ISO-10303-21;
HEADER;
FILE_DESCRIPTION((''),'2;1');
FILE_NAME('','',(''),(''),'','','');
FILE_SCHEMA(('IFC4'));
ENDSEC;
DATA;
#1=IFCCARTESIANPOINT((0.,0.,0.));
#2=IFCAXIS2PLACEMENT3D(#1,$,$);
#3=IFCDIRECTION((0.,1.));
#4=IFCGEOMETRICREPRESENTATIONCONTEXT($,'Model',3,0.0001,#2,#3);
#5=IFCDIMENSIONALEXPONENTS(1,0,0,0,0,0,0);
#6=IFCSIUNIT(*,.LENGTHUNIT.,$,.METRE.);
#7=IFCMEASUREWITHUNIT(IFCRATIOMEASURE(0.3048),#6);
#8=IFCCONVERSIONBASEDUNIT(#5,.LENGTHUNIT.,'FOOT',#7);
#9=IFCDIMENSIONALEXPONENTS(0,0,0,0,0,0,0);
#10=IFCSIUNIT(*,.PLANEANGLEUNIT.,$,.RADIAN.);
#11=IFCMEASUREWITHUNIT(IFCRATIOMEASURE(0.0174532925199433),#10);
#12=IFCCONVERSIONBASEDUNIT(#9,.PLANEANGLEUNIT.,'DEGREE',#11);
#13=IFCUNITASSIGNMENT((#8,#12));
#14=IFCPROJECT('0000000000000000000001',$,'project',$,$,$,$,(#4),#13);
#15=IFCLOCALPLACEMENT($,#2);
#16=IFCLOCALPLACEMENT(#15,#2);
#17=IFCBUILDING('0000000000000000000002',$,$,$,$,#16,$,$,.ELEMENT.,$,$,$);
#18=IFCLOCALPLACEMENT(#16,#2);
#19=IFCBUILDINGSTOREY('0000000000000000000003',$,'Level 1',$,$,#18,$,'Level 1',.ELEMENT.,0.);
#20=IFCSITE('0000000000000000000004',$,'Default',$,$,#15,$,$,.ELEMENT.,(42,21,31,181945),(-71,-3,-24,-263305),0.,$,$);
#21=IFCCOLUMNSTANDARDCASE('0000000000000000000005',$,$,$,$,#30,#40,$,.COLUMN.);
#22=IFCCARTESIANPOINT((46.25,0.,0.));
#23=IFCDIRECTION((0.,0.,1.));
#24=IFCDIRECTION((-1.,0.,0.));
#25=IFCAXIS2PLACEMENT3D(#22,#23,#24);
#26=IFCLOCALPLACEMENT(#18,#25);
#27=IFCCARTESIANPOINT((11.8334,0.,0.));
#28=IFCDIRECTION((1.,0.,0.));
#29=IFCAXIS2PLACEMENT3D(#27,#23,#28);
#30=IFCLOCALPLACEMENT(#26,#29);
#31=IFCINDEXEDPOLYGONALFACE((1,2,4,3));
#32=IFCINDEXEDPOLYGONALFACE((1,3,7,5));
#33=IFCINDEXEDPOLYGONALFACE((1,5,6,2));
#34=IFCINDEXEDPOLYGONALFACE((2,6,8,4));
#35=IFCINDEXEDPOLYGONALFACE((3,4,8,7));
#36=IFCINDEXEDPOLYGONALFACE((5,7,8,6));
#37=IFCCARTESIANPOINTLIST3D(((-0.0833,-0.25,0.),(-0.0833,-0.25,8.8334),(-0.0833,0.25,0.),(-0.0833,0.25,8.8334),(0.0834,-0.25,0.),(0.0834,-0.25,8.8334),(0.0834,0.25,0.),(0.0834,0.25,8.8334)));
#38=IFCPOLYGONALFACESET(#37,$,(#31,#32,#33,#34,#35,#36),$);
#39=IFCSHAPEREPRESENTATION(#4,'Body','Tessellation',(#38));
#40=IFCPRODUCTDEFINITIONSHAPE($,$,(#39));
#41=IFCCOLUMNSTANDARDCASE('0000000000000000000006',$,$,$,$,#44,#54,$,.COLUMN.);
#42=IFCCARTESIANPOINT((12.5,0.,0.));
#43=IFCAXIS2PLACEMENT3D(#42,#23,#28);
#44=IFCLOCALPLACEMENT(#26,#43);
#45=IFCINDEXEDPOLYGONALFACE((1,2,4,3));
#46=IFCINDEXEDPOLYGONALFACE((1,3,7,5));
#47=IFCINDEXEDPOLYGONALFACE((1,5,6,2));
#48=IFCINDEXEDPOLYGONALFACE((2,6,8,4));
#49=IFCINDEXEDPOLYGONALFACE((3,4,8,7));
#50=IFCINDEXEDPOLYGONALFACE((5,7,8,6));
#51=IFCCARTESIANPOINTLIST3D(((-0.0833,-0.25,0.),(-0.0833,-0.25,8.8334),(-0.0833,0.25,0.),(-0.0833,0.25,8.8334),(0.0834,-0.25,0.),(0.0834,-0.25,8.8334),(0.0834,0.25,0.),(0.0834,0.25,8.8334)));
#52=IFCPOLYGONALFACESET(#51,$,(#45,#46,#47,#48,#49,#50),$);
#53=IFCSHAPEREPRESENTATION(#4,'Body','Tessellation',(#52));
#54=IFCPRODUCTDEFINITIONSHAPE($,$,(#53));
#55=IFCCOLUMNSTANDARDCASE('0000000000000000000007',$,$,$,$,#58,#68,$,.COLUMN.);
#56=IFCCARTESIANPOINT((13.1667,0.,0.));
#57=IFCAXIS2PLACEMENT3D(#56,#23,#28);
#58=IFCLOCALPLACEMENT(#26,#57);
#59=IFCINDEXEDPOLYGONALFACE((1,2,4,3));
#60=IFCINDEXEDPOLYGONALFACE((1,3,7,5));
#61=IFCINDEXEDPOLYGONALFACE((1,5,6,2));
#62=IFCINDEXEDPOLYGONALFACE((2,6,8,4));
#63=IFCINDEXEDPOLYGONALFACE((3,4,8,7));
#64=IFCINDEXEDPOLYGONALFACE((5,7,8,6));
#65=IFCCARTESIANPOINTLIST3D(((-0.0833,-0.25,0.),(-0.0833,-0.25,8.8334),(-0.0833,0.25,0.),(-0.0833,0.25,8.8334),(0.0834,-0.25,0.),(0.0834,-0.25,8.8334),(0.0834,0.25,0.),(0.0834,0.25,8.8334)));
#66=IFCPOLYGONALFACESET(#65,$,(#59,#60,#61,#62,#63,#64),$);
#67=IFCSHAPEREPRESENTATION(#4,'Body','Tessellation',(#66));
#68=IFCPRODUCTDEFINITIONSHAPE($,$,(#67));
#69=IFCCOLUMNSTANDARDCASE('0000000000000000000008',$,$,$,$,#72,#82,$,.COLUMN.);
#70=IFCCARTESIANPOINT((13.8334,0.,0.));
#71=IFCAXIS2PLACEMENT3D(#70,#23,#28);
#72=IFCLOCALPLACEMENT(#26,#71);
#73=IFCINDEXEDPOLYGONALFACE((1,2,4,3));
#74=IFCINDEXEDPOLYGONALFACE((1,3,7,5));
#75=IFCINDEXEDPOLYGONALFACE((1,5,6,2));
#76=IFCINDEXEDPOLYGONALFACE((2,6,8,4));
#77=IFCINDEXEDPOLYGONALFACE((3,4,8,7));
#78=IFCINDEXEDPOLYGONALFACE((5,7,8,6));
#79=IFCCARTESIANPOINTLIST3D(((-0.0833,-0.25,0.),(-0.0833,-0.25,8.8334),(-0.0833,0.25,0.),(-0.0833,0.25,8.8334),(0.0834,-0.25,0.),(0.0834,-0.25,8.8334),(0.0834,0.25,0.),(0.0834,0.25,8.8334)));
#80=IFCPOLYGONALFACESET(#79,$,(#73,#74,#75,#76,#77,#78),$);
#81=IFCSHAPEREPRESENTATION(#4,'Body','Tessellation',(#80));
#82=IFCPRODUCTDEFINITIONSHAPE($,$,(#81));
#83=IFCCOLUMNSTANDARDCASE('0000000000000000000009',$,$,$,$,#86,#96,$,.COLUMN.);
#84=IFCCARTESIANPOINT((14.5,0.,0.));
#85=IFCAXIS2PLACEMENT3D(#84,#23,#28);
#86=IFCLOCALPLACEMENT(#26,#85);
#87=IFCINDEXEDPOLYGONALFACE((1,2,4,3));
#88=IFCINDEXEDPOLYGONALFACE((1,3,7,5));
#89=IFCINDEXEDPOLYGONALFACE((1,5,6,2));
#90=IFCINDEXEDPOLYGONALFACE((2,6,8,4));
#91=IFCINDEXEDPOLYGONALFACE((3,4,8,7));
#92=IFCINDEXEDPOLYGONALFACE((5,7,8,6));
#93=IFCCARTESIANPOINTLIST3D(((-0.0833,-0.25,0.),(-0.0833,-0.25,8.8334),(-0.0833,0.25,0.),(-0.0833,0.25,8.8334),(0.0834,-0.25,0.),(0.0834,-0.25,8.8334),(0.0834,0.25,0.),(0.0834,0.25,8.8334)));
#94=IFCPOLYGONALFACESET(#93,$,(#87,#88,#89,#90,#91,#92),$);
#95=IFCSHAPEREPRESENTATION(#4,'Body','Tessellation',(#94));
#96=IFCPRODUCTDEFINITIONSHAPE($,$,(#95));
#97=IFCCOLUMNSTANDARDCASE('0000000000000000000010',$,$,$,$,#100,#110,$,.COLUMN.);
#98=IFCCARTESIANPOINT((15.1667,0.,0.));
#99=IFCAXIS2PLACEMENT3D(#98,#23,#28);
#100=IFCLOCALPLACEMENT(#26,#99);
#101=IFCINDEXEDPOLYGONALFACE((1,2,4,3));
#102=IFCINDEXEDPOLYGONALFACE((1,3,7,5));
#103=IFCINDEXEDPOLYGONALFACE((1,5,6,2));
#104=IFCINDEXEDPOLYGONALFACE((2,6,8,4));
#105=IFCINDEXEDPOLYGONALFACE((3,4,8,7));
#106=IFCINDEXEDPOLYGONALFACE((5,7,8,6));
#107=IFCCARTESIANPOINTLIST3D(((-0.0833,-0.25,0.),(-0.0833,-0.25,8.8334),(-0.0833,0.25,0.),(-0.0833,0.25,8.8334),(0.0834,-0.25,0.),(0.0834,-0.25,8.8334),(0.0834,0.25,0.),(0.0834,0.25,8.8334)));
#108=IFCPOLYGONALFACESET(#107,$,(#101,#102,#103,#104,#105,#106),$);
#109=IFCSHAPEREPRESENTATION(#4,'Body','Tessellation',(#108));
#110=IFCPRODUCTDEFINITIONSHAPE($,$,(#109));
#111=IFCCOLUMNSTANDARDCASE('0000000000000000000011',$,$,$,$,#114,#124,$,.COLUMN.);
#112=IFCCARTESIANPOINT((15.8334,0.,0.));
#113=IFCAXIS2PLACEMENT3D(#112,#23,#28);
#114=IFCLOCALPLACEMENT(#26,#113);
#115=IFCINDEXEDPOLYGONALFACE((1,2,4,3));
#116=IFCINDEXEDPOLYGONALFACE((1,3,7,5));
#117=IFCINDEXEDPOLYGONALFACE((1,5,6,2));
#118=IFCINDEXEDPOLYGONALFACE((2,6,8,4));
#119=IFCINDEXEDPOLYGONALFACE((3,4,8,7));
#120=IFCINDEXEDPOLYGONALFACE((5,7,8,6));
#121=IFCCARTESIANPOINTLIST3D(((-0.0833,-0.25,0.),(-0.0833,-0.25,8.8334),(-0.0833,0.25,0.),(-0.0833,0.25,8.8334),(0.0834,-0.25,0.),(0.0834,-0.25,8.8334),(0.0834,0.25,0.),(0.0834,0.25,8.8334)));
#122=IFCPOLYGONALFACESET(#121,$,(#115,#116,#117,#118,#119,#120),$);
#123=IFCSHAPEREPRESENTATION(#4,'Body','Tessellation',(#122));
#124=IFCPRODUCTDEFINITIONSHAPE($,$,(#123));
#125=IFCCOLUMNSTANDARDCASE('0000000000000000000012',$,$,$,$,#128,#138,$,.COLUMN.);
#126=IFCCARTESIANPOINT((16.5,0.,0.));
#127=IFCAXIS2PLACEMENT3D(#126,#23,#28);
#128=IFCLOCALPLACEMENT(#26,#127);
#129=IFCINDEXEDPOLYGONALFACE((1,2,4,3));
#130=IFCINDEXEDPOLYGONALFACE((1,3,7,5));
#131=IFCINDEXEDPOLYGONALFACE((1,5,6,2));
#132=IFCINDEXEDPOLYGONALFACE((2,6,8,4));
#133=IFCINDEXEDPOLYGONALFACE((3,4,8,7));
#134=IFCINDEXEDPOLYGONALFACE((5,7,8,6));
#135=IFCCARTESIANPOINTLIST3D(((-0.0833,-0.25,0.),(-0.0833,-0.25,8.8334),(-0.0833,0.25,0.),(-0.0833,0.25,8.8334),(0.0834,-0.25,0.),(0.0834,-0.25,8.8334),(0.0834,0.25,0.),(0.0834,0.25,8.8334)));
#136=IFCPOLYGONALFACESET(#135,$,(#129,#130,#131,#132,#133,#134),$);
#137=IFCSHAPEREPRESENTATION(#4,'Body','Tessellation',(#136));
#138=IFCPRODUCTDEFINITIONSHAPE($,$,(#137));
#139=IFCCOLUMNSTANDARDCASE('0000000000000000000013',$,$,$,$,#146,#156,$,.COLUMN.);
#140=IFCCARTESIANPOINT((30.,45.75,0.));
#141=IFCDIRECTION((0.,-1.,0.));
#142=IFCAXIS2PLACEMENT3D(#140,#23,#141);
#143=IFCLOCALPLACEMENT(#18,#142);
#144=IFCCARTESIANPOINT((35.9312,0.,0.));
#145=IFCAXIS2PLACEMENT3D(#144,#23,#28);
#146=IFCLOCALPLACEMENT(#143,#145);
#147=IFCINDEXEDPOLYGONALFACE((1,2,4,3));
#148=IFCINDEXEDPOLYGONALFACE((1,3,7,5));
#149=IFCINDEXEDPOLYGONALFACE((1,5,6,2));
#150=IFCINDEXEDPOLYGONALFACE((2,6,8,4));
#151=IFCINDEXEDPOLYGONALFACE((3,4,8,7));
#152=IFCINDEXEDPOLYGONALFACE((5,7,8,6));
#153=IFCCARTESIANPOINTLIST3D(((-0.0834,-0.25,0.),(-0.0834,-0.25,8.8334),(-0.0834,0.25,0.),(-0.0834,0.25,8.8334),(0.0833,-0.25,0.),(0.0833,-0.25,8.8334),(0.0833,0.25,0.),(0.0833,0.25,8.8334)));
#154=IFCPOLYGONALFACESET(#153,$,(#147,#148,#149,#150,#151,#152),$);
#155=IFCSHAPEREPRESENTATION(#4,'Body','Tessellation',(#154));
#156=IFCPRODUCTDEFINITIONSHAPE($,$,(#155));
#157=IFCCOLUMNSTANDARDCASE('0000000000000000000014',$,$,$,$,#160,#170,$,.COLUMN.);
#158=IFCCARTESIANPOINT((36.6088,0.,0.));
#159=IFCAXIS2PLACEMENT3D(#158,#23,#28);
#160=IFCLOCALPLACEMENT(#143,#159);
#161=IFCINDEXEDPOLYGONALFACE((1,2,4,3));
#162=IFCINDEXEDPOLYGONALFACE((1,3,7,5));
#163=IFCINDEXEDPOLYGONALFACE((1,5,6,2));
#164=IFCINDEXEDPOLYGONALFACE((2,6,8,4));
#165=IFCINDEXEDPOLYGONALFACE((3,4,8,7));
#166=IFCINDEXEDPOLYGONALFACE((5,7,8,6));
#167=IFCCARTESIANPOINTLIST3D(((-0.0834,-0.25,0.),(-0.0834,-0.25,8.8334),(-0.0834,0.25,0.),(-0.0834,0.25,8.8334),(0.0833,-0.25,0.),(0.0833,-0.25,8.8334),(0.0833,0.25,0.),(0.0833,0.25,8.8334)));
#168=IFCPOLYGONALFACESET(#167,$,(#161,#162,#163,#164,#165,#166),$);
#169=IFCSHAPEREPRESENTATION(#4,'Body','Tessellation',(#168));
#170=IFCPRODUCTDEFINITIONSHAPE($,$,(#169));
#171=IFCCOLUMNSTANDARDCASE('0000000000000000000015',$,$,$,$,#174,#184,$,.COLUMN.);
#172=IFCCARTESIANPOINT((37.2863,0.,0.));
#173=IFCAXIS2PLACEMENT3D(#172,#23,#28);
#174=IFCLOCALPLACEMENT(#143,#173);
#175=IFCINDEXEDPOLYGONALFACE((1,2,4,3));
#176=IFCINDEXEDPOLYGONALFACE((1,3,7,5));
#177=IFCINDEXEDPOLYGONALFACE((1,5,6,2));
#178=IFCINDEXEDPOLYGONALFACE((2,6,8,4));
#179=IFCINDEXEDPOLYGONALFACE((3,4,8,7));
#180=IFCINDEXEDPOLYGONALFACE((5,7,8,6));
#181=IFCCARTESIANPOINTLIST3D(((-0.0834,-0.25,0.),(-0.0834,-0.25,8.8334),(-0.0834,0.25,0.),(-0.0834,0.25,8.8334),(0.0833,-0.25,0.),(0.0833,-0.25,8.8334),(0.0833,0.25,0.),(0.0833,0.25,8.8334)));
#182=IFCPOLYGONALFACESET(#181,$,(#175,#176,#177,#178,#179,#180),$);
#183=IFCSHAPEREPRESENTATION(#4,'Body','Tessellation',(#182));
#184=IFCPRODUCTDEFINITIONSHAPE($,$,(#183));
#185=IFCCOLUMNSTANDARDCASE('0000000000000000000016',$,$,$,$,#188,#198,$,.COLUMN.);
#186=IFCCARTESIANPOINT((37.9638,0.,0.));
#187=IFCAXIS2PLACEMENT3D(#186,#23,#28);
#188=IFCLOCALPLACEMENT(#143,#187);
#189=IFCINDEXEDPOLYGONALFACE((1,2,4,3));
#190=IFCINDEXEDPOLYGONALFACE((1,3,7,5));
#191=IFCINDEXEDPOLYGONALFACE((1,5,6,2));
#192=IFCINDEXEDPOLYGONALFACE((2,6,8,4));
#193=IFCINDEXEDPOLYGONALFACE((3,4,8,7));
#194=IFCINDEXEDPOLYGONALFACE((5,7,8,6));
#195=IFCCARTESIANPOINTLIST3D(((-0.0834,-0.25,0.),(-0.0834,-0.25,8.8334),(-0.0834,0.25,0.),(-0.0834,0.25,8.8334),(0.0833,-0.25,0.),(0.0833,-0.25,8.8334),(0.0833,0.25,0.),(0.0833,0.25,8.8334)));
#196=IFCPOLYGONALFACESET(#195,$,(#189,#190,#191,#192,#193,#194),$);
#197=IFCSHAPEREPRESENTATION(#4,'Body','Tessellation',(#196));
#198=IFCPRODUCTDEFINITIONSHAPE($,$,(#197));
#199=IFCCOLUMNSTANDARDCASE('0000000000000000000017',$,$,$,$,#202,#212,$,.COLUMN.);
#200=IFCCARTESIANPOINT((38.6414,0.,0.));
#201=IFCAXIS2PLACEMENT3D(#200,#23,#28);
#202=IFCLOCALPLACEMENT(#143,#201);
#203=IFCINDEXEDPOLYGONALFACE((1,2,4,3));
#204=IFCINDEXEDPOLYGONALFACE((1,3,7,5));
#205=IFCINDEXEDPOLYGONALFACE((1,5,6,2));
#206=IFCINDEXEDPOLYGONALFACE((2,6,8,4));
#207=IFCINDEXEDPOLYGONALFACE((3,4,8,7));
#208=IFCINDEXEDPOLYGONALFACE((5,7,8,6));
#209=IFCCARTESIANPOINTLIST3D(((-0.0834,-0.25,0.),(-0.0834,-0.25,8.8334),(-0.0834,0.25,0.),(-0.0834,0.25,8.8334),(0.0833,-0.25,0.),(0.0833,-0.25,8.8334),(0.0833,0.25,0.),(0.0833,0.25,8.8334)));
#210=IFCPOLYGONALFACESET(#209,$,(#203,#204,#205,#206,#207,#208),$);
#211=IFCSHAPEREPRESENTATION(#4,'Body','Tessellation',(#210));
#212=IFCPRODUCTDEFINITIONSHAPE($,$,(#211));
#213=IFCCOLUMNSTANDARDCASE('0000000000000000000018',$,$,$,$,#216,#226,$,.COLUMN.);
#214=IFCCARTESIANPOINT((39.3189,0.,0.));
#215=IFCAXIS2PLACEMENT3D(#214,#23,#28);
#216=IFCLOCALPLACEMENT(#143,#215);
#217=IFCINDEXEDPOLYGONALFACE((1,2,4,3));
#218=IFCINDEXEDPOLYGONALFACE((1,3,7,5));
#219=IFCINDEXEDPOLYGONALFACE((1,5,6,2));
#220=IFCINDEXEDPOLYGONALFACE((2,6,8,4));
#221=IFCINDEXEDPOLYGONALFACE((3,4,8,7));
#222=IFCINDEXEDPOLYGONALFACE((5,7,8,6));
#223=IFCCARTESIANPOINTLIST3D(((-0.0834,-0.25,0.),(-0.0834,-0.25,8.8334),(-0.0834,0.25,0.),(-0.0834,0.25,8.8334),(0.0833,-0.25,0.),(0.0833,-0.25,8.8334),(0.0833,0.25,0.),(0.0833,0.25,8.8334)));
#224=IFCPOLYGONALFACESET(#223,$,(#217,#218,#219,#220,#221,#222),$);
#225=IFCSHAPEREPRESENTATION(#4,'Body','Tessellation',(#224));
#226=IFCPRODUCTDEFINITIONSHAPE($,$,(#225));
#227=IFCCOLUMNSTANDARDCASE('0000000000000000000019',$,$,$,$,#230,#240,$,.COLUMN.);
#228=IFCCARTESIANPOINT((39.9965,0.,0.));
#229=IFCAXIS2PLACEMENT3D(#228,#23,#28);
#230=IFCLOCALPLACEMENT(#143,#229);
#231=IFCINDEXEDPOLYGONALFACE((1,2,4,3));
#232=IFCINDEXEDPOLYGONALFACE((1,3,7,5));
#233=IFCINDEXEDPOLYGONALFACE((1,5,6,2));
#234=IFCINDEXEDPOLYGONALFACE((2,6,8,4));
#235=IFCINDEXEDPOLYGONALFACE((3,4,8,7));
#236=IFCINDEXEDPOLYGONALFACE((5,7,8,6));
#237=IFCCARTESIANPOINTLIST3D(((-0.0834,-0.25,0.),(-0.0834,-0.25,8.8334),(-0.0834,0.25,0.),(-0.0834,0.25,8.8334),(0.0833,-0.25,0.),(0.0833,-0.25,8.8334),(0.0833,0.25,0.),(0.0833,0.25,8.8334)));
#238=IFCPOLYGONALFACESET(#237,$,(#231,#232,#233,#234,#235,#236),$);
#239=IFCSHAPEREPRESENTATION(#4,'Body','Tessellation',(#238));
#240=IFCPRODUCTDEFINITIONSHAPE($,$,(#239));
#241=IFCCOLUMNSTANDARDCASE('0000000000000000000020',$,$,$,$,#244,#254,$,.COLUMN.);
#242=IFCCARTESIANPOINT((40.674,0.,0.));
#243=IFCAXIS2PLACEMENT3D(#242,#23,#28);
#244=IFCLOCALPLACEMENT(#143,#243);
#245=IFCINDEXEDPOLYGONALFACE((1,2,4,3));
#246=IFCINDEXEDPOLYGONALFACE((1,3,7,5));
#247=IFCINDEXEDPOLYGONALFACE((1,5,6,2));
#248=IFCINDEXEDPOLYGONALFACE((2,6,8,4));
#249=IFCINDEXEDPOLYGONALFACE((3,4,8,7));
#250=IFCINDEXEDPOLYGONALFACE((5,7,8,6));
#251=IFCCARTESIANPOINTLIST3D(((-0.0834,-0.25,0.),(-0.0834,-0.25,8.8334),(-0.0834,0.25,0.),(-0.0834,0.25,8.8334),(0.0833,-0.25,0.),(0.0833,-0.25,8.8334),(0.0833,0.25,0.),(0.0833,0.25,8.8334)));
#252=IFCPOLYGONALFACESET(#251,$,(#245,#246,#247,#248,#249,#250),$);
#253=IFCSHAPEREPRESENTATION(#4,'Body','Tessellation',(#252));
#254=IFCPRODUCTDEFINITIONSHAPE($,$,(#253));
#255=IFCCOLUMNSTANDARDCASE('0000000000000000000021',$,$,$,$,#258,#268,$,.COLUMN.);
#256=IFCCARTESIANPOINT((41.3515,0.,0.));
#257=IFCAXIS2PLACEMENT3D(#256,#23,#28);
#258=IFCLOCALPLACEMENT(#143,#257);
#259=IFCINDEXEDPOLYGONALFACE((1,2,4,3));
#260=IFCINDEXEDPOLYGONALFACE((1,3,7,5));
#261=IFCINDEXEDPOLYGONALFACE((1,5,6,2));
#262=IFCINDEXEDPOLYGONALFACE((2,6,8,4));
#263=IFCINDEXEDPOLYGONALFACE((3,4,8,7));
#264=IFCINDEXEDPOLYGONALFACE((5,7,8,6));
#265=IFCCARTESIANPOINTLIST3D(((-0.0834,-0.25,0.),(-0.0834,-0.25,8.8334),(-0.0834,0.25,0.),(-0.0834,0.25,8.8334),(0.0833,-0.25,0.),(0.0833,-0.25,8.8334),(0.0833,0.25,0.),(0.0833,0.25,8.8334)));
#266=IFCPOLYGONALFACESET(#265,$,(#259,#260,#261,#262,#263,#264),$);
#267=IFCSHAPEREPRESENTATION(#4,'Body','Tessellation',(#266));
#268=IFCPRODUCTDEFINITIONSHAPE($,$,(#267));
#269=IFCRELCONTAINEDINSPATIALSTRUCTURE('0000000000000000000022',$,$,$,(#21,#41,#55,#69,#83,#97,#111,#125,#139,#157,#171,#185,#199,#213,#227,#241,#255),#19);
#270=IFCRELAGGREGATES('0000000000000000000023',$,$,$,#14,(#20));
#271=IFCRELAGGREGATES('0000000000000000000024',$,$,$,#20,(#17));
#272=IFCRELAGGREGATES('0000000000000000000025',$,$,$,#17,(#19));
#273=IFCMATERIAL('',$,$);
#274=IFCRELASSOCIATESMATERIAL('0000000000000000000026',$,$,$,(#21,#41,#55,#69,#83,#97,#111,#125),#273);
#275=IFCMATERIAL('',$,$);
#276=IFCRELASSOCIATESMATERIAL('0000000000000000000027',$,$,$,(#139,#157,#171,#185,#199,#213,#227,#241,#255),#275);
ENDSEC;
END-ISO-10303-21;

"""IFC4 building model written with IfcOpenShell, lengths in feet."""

from ifc_helpers import new_model, entity, si_unit, converted_unit, direction, frame, origin, place, context, project, spatial, rectangle, extrude, material, element, save


model = new_model("IFC4")

# Units and contexts
model_context = context("Model", 3, precision=0.0001, world=origin(), true_north=direction((0.0, 1.0)))
ifc_project = project(units=[converted_unit("LENGTHUNIT", "FOOT", entity("IfcRatioMeasure", 0.3048), si_unit("LENGTHUNIT", "METRE"), dimensions=[1, 0, 0, 0, 0, 0, 0]), converted_unit("PLANEANGLEUNIT", "DEGREE", entity("IfcRatioMeasure", 0.0174532925199433), si_unit("PLANEANGLEUNIT", "RADIAN"), dimensions=[0, 0, 0, 0, 0, 0, 0])], contexts=[model_context])

# Site, building, storey
site_placement = place(None, origin())
site = spatial("IfcSite", under=ifc_project, at=site_placement, Name="Default", CompositionType="ELEMENT", RefLatitude=(42, 21, 31, 181945), RefLongitude=(-71, -3, -24, -263305), RefElevation=0.0)
building_placement = place(site_placement, origin())
building = spatial("IfcBuilding", under=site, at=building_placement, CompositionType="ELEMENT")
storey_placement = place(building_placement, origin())
storey = spatial("IfcBuildingStorey", under=building, at=storey_placement, Name="Level 1", LongName="Level 1", CompositionType="ELEMENT", Elevation=0.0)

# Columns
ifc_material_1 = material(Name="")
placement_1 = place(storey_placement, frame((46.25, 0.0, 0.0), z_axis=(0.0, 0.0, 1.0), x_axis=(-1.0, 0.0, 0.0)))
for number, where, z_axis, x_axis in (
    (1, (11.8334, 0.0, 0.0), (0.0, 0.0, 1.0), (1.0, 0.0, 0.0)),
    (2, (12.5, 0.0, 0.0), (0.0, 0.0, 1.0), (1.0, 0.0, 0.0)),
    (3, (13.1667, 0.0, 0.0), (0.0, 0.0, 1.0), (1.0, 0.0, 0.0)),
    (4, (13.8334, 0.0, 0.0), (0.0, 0.0, 1.0), (1.0, 0.0, 0.0)),
    (5, (14.5, 0.0, 0.0), (0.0, 0.0, 1.0), (1.0, 0.0, 0.0)),
    (6, (15.1667, 0.0, 0.0), (0.0, 0.0, 1.0), (1.0, 0.0, 0.0)),
    (7, (15.8334, 0.0, 0.0), (0.0, 0.0, 1.0), (1.0, 0.0, 0.0)),
    (8, (16.5, 0.0, 0.0), (0.0, 0.0, 1.0), (1.0, 0.0, 0.0)),
):
    element("IfcColumnStandardCase", number, at=place(placement_1, frame(where, z_axis=z_axis, x_axis=x_axis)), inside=storey, material=ifc_material_1, PredefinedType="COLUMN", context=model_context, shape_type="SweptSolid", body=[
        extrude(rectangle(XDim=0.1667, YDim=0.5), origin(), (0.0, 0.0, 1.0), 8.8334),
    ])
ifc_material_2 = material(Name="")
placement_2 = place(storey_placement, frame((30.0, 45.75, 0.0), z_axis=(0.0, 0.0, 1.0), x_axis=(0.0, -1.0, 0.0)))
for number, where, z_axis, x_axis in (
    (9, (35.9312, 0.0, 0.0), (0.0, 0.0, 1.0), (1.0, 0.0, 0.0)),
    (10, (36.6088, 0.0, 0.0), (0.0, 0.0, 1.0), (1.0, 0.0, 0.0)),
    (11, (37.2863, 0.0, 0.0), (0.0, 0.0, 1.0), (1.0, 0.0, 0.0)),
    (12, (37.9638, 0.0, 0.0), (0.0, 0.0, 1.0), (1.0, 0.0, 0.0)),
    (13, (38.6414, 0.0, 0.0), (0.0, 0.0, 1.0), (1.0, 0.0, 0.0)),
    (14, (39.3189, 0.0, 0.0), (0.0, 0.0, 1.0), (1.0, 0.0, 0.0)),
    (15, (39.9965, 0.0, 0.0), (0.0, 0.0, 1.0), (1.0, 0.0, 0.0)),
    (16, (40.674, 0.0, 0.0), (0.0, 0.0, 1.0), (1.0, 0.0, 0.0)),
    (17, (41.3515, 0.0, 0.0), (0.0, 0.0, 1.0), (1.0, 0.0, 0.0)),
):
    element("IfcColumnStandardCase", number, at=place(placement_2, frame(where, z_axis=z_axis, x_axis=x_axis)), inside=storey, material=ifc_material_2, PredefinedType="COLUMN", context=model_context, shape_type="SweptSolid", body=[
        extrude(rectangle(XDim=0.1667, YDim=0.5), origin(), (0.0, 0.0, 1.0), 8.8334),
    ])

save(model, "model.ifc")
